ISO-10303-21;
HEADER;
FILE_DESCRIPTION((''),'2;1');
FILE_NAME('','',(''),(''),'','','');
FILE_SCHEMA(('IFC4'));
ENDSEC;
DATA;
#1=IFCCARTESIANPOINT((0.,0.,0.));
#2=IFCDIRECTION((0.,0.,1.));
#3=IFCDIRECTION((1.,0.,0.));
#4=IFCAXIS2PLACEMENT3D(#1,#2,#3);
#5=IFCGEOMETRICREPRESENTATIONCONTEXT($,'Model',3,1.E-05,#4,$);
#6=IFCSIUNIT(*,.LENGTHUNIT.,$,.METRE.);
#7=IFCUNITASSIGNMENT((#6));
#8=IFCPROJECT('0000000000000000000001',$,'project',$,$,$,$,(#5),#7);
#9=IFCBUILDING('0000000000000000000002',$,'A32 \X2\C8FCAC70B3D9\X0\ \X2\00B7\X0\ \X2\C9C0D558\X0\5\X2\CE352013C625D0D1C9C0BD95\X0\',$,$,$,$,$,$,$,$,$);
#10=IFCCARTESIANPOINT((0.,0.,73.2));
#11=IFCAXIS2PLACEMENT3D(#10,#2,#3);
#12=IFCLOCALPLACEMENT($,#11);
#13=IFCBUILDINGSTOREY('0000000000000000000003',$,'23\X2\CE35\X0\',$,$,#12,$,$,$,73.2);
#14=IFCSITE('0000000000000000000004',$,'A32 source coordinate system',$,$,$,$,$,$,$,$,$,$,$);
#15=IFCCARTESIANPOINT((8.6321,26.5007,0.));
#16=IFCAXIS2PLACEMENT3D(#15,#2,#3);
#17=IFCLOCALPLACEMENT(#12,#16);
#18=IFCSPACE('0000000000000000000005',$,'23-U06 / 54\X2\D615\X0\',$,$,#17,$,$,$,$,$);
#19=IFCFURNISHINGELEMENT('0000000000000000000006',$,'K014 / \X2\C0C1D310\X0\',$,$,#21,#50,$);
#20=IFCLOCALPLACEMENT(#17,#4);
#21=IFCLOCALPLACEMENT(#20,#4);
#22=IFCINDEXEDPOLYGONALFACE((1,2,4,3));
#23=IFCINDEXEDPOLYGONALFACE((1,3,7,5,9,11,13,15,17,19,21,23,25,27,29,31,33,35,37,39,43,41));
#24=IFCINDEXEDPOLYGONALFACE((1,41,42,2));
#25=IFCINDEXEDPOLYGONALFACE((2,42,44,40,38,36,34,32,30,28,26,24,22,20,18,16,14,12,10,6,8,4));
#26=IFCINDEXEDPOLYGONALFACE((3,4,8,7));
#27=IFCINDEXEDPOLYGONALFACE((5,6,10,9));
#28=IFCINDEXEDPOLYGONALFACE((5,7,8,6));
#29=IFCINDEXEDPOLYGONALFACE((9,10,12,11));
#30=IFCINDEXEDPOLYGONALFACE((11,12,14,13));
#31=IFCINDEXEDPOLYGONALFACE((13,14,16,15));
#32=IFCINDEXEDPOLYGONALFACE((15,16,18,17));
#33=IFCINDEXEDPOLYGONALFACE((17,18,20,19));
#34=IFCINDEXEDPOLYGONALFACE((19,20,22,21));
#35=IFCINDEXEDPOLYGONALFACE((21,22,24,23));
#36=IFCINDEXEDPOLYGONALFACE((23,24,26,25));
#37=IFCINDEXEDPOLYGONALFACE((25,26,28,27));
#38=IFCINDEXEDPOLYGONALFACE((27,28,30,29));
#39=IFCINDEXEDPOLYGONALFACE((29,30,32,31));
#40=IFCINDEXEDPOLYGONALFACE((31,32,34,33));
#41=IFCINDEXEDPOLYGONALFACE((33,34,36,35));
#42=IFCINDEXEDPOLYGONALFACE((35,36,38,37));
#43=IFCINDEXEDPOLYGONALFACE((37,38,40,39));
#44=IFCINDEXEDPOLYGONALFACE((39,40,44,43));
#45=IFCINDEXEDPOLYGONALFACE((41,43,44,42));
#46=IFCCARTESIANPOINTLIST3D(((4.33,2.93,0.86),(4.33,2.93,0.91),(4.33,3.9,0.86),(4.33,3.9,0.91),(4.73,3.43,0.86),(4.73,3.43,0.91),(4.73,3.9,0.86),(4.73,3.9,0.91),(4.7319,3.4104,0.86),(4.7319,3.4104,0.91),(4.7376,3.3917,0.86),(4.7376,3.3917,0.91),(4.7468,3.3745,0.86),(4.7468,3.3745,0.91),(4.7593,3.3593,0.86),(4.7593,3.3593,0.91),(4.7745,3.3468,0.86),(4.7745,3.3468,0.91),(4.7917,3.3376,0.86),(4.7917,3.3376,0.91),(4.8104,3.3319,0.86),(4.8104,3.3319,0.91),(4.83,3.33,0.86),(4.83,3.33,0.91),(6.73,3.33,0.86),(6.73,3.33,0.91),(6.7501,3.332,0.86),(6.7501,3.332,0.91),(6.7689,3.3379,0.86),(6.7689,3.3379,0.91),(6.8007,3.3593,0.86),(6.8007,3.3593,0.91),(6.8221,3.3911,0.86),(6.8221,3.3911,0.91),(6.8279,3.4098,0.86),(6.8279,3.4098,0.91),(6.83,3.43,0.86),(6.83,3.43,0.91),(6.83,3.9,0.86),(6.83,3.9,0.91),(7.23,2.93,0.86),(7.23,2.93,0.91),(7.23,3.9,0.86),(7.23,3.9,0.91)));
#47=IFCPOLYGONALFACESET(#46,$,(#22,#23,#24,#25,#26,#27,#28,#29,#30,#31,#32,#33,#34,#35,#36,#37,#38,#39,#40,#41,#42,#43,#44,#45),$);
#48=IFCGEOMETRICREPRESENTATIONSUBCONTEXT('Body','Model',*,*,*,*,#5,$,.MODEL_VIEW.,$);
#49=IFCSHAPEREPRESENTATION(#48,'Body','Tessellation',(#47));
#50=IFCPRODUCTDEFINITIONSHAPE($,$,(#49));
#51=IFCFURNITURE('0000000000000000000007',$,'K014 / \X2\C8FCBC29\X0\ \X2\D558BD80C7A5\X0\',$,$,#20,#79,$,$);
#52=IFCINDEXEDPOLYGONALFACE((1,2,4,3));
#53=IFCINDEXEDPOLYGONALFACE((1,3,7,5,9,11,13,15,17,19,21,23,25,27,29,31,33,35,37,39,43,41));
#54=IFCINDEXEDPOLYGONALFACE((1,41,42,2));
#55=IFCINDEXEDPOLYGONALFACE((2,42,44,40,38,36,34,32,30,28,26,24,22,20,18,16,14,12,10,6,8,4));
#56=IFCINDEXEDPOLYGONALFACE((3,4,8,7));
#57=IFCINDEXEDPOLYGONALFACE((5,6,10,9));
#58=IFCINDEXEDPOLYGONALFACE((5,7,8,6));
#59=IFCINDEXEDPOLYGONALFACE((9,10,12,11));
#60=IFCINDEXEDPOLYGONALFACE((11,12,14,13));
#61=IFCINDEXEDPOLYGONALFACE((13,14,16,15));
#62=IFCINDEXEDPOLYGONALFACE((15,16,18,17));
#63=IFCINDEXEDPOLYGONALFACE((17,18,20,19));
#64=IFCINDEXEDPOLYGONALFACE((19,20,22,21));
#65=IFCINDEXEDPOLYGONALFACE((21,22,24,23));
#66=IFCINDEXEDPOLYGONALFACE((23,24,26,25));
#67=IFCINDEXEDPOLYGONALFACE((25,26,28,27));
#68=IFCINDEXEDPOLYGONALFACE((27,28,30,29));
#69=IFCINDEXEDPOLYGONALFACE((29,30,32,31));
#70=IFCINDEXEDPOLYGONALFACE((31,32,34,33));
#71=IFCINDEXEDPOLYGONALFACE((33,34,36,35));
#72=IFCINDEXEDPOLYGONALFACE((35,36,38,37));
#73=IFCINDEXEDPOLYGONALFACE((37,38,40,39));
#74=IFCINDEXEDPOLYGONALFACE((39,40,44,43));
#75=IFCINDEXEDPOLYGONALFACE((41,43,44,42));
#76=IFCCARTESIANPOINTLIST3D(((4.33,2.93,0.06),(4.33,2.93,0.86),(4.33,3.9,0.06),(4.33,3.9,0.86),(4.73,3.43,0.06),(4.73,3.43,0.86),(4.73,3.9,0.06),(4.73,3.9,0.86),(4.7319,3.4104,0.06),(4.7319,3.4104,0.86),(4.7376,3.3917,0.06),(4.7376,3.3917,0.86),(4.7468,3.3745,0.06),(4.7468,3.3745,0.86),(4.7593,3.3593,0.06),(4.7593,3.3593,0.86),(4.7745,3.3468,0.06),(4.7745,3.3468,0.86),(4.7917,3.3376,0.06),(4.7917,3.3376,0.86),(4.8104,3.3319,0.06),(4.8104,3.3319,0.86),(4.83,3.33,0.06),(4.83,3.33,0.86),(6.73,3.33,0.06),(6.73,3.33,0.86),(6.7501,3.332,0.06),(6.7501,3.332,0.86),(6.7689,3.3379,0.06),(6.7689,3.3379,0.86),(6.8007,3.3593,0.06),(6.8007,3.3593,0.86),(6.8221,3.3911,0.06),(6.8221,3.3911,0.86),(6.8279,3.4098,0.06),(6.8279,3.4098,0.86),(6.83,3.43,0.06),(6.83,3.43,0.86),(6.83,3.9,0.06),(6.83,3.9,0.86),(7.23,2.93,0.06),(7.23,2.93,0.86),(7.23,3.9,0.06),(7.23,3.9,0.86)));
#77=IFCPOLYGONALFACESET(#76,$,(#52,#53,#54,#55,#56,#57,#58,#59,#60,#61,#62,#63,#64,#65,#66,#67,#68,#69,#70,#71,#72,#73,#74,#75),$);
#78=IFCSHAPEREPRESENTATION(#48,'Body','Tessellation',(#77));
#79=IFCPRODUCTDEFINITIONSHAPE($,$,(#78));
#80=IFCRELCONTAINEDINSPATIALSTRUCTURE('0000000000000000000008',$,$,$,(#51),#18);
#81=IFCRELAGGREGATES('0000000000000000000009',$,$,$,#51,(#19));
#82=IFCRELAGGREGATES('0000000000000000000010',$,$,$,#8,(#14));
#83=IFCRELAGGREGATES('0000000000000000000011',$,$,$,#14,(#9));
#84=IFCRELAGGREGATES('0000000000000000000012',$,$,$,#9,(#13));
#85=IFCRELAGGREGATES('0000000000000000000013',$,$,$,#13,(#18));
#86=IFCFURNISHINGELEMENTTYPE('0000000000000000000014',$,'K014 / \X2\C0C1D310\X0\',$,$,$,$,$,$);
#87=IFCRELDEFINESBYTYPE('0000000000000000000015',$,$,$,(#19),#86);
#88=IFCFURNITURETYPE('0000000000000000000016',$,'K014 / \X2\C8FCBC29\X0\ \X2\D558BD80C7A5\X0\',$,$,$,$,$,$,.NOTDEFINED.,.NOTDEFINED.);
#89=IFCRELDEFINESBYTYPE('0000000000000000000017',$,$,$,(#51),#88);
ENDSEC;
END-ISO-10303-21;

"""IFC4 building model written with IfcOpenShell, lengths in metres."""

from ifc_helpers import new_model, si_unit, frame, origin, origin_with_axes, place, context, subcontext, project, spatial, polyline, outline, extrude, source, transform, mapped, type_object, type_shapes, element, aggregate, save


model = new_model("IFC4")

# Units and contexts
model_context = context("Model", 3, precision=1e-05, world=origin_with_axes())
body_context = subcontext(model_context, "Body", "Model", "MODEL_VIEW")
ifc_project = project(units=[si_unit("LENGTHUNIT", "METRE")], contexts=[model_context])

# Site, building, storey, space
site = spatial("IfcSite", under=ifc_project, Name="A32 source coordinate system")
building = spatial("IfcBuilding", under=site, Name="A32 주거동 · 지하5층–옥탑지붕")
storey_placement = place(None, frame((0.0, 0.0, 73.2), z_axis=(0.0, 0.0, 1.0), x_axis=(1.0, 0.0, 0.0)))
storey = spatial("IfcBuildingStorey", under=building, at=storey_placement, Name="23층", Elevation=73.2)
space_placement = place(storey_placement, frame((8.6321, 26.5007, 0.0), z_axis=(0.0, 0.0, 1.0), x_axis=(1.0, 0.0, 0.0)))
space = spatial("IfcSpace", under=storey, at=space_placement, Name="23-U06 / 54형")

# Furnishing element
furnishing_element_type_1 = type_object("IfcFurnishingElementType", Name="K014 / 상판")
shared_shape_1 = source(origin(), body_context, "Body", "SweptSolid", [
    extrude(outline(polyline([(4.33, 2.93), (4.33, 3.9), (4.73, 3.9), (4.73, 3.43), (4.7319, 3.4104), (4.7376, 3.3917), (4.7468, 3.3745), (4.7593, 3.3593), (4.7745, 3.3468), (4.7917, 3.3376), (4.8104, 3.3319), (4.83, 3.33), (6.73, 3.33), (6.7501, 3.332), (6.7689, 3.3379), (6.8007, 3.3593), (6.8221, 3.3911), (6.8279, 3.4098), (6.83, 3.43), (6.83, 3.9), (7.23, 3.9), (7.23, 2.93), (4.33, 2.93)])), frame((0.0, 0.0, 0.86)), (0.0, 0.0, 1.0), 0.05),
])
type_shapes(furnishing_element_type_1, [shared_shape_1])
furniture_1_placement = place(space_placement, origin_with_axes())
furnishing_1_placement = place(furniture_1_placement, origin_with_axes())
furnishing_1 = element("IfcFurnishingElement", 1, at=furnishing_1_placement, type_object=furnishing_element_type_1, Name="K014 / 상판", context=body_context, shape_type="MappedRepresentation", body=[
    mapped(shared_shape_1, transform((0.0, 0.0, 0.0), scale=1.0)),
])

# Furniture
furniture_type_1 = type_object("IfcFurnitureType", Name="K014 / 주방 하부장", AssemblyPlace="NOTDEFINED", PredefinedType="NOTDEFINED")
shared_shape_2 = source(origin(), body_context, "Body", "SweptSolid", [
    extrude(outline(polyline([(7.23, 2.93), (4.33, 2.93), (4.33, 3.9), (4.73, 3.9), (4.73, 3.43), (4.7319, 3.4104), (4.7376, 3.3917), (4.7468, 3.3745), (4.7593, 3.3593), (4.7745, 3.3468), (4.7917, 3.3376), (4.8104, 3.3319), (4.83, 3.33), (6.73, 3.33), (6.7501, 3.332), (6.7689, 3.3379), (6.8007, 3.3593), (6.8221, 3.3911), (6.8279, 3.4098), (6.83, 3.43), (6.83, 3.9), (7.23, 3.9), (7.23, 2.93)])), frame((0.0, 0.0, 0.06)), (0.0, 0.0, 1.0), 0.8),
])
type_shapes(furniture_type_1, [shared_shape_2])
furniture_1 = element("IfcFurniture", 2, at=furniture_1_placement, inside=space, type_object=furniture_type_1, Name="K014 / 주방 하부장", context=body_context, shape_type="MappedRepresentation", body=[
    mapped(shared_shape_2, transform((0.0, 0.0, 0.0), scale=1.0)),
])
aggregate(furniture_1, [furnishing_1])

save(model, "model.ifc")
